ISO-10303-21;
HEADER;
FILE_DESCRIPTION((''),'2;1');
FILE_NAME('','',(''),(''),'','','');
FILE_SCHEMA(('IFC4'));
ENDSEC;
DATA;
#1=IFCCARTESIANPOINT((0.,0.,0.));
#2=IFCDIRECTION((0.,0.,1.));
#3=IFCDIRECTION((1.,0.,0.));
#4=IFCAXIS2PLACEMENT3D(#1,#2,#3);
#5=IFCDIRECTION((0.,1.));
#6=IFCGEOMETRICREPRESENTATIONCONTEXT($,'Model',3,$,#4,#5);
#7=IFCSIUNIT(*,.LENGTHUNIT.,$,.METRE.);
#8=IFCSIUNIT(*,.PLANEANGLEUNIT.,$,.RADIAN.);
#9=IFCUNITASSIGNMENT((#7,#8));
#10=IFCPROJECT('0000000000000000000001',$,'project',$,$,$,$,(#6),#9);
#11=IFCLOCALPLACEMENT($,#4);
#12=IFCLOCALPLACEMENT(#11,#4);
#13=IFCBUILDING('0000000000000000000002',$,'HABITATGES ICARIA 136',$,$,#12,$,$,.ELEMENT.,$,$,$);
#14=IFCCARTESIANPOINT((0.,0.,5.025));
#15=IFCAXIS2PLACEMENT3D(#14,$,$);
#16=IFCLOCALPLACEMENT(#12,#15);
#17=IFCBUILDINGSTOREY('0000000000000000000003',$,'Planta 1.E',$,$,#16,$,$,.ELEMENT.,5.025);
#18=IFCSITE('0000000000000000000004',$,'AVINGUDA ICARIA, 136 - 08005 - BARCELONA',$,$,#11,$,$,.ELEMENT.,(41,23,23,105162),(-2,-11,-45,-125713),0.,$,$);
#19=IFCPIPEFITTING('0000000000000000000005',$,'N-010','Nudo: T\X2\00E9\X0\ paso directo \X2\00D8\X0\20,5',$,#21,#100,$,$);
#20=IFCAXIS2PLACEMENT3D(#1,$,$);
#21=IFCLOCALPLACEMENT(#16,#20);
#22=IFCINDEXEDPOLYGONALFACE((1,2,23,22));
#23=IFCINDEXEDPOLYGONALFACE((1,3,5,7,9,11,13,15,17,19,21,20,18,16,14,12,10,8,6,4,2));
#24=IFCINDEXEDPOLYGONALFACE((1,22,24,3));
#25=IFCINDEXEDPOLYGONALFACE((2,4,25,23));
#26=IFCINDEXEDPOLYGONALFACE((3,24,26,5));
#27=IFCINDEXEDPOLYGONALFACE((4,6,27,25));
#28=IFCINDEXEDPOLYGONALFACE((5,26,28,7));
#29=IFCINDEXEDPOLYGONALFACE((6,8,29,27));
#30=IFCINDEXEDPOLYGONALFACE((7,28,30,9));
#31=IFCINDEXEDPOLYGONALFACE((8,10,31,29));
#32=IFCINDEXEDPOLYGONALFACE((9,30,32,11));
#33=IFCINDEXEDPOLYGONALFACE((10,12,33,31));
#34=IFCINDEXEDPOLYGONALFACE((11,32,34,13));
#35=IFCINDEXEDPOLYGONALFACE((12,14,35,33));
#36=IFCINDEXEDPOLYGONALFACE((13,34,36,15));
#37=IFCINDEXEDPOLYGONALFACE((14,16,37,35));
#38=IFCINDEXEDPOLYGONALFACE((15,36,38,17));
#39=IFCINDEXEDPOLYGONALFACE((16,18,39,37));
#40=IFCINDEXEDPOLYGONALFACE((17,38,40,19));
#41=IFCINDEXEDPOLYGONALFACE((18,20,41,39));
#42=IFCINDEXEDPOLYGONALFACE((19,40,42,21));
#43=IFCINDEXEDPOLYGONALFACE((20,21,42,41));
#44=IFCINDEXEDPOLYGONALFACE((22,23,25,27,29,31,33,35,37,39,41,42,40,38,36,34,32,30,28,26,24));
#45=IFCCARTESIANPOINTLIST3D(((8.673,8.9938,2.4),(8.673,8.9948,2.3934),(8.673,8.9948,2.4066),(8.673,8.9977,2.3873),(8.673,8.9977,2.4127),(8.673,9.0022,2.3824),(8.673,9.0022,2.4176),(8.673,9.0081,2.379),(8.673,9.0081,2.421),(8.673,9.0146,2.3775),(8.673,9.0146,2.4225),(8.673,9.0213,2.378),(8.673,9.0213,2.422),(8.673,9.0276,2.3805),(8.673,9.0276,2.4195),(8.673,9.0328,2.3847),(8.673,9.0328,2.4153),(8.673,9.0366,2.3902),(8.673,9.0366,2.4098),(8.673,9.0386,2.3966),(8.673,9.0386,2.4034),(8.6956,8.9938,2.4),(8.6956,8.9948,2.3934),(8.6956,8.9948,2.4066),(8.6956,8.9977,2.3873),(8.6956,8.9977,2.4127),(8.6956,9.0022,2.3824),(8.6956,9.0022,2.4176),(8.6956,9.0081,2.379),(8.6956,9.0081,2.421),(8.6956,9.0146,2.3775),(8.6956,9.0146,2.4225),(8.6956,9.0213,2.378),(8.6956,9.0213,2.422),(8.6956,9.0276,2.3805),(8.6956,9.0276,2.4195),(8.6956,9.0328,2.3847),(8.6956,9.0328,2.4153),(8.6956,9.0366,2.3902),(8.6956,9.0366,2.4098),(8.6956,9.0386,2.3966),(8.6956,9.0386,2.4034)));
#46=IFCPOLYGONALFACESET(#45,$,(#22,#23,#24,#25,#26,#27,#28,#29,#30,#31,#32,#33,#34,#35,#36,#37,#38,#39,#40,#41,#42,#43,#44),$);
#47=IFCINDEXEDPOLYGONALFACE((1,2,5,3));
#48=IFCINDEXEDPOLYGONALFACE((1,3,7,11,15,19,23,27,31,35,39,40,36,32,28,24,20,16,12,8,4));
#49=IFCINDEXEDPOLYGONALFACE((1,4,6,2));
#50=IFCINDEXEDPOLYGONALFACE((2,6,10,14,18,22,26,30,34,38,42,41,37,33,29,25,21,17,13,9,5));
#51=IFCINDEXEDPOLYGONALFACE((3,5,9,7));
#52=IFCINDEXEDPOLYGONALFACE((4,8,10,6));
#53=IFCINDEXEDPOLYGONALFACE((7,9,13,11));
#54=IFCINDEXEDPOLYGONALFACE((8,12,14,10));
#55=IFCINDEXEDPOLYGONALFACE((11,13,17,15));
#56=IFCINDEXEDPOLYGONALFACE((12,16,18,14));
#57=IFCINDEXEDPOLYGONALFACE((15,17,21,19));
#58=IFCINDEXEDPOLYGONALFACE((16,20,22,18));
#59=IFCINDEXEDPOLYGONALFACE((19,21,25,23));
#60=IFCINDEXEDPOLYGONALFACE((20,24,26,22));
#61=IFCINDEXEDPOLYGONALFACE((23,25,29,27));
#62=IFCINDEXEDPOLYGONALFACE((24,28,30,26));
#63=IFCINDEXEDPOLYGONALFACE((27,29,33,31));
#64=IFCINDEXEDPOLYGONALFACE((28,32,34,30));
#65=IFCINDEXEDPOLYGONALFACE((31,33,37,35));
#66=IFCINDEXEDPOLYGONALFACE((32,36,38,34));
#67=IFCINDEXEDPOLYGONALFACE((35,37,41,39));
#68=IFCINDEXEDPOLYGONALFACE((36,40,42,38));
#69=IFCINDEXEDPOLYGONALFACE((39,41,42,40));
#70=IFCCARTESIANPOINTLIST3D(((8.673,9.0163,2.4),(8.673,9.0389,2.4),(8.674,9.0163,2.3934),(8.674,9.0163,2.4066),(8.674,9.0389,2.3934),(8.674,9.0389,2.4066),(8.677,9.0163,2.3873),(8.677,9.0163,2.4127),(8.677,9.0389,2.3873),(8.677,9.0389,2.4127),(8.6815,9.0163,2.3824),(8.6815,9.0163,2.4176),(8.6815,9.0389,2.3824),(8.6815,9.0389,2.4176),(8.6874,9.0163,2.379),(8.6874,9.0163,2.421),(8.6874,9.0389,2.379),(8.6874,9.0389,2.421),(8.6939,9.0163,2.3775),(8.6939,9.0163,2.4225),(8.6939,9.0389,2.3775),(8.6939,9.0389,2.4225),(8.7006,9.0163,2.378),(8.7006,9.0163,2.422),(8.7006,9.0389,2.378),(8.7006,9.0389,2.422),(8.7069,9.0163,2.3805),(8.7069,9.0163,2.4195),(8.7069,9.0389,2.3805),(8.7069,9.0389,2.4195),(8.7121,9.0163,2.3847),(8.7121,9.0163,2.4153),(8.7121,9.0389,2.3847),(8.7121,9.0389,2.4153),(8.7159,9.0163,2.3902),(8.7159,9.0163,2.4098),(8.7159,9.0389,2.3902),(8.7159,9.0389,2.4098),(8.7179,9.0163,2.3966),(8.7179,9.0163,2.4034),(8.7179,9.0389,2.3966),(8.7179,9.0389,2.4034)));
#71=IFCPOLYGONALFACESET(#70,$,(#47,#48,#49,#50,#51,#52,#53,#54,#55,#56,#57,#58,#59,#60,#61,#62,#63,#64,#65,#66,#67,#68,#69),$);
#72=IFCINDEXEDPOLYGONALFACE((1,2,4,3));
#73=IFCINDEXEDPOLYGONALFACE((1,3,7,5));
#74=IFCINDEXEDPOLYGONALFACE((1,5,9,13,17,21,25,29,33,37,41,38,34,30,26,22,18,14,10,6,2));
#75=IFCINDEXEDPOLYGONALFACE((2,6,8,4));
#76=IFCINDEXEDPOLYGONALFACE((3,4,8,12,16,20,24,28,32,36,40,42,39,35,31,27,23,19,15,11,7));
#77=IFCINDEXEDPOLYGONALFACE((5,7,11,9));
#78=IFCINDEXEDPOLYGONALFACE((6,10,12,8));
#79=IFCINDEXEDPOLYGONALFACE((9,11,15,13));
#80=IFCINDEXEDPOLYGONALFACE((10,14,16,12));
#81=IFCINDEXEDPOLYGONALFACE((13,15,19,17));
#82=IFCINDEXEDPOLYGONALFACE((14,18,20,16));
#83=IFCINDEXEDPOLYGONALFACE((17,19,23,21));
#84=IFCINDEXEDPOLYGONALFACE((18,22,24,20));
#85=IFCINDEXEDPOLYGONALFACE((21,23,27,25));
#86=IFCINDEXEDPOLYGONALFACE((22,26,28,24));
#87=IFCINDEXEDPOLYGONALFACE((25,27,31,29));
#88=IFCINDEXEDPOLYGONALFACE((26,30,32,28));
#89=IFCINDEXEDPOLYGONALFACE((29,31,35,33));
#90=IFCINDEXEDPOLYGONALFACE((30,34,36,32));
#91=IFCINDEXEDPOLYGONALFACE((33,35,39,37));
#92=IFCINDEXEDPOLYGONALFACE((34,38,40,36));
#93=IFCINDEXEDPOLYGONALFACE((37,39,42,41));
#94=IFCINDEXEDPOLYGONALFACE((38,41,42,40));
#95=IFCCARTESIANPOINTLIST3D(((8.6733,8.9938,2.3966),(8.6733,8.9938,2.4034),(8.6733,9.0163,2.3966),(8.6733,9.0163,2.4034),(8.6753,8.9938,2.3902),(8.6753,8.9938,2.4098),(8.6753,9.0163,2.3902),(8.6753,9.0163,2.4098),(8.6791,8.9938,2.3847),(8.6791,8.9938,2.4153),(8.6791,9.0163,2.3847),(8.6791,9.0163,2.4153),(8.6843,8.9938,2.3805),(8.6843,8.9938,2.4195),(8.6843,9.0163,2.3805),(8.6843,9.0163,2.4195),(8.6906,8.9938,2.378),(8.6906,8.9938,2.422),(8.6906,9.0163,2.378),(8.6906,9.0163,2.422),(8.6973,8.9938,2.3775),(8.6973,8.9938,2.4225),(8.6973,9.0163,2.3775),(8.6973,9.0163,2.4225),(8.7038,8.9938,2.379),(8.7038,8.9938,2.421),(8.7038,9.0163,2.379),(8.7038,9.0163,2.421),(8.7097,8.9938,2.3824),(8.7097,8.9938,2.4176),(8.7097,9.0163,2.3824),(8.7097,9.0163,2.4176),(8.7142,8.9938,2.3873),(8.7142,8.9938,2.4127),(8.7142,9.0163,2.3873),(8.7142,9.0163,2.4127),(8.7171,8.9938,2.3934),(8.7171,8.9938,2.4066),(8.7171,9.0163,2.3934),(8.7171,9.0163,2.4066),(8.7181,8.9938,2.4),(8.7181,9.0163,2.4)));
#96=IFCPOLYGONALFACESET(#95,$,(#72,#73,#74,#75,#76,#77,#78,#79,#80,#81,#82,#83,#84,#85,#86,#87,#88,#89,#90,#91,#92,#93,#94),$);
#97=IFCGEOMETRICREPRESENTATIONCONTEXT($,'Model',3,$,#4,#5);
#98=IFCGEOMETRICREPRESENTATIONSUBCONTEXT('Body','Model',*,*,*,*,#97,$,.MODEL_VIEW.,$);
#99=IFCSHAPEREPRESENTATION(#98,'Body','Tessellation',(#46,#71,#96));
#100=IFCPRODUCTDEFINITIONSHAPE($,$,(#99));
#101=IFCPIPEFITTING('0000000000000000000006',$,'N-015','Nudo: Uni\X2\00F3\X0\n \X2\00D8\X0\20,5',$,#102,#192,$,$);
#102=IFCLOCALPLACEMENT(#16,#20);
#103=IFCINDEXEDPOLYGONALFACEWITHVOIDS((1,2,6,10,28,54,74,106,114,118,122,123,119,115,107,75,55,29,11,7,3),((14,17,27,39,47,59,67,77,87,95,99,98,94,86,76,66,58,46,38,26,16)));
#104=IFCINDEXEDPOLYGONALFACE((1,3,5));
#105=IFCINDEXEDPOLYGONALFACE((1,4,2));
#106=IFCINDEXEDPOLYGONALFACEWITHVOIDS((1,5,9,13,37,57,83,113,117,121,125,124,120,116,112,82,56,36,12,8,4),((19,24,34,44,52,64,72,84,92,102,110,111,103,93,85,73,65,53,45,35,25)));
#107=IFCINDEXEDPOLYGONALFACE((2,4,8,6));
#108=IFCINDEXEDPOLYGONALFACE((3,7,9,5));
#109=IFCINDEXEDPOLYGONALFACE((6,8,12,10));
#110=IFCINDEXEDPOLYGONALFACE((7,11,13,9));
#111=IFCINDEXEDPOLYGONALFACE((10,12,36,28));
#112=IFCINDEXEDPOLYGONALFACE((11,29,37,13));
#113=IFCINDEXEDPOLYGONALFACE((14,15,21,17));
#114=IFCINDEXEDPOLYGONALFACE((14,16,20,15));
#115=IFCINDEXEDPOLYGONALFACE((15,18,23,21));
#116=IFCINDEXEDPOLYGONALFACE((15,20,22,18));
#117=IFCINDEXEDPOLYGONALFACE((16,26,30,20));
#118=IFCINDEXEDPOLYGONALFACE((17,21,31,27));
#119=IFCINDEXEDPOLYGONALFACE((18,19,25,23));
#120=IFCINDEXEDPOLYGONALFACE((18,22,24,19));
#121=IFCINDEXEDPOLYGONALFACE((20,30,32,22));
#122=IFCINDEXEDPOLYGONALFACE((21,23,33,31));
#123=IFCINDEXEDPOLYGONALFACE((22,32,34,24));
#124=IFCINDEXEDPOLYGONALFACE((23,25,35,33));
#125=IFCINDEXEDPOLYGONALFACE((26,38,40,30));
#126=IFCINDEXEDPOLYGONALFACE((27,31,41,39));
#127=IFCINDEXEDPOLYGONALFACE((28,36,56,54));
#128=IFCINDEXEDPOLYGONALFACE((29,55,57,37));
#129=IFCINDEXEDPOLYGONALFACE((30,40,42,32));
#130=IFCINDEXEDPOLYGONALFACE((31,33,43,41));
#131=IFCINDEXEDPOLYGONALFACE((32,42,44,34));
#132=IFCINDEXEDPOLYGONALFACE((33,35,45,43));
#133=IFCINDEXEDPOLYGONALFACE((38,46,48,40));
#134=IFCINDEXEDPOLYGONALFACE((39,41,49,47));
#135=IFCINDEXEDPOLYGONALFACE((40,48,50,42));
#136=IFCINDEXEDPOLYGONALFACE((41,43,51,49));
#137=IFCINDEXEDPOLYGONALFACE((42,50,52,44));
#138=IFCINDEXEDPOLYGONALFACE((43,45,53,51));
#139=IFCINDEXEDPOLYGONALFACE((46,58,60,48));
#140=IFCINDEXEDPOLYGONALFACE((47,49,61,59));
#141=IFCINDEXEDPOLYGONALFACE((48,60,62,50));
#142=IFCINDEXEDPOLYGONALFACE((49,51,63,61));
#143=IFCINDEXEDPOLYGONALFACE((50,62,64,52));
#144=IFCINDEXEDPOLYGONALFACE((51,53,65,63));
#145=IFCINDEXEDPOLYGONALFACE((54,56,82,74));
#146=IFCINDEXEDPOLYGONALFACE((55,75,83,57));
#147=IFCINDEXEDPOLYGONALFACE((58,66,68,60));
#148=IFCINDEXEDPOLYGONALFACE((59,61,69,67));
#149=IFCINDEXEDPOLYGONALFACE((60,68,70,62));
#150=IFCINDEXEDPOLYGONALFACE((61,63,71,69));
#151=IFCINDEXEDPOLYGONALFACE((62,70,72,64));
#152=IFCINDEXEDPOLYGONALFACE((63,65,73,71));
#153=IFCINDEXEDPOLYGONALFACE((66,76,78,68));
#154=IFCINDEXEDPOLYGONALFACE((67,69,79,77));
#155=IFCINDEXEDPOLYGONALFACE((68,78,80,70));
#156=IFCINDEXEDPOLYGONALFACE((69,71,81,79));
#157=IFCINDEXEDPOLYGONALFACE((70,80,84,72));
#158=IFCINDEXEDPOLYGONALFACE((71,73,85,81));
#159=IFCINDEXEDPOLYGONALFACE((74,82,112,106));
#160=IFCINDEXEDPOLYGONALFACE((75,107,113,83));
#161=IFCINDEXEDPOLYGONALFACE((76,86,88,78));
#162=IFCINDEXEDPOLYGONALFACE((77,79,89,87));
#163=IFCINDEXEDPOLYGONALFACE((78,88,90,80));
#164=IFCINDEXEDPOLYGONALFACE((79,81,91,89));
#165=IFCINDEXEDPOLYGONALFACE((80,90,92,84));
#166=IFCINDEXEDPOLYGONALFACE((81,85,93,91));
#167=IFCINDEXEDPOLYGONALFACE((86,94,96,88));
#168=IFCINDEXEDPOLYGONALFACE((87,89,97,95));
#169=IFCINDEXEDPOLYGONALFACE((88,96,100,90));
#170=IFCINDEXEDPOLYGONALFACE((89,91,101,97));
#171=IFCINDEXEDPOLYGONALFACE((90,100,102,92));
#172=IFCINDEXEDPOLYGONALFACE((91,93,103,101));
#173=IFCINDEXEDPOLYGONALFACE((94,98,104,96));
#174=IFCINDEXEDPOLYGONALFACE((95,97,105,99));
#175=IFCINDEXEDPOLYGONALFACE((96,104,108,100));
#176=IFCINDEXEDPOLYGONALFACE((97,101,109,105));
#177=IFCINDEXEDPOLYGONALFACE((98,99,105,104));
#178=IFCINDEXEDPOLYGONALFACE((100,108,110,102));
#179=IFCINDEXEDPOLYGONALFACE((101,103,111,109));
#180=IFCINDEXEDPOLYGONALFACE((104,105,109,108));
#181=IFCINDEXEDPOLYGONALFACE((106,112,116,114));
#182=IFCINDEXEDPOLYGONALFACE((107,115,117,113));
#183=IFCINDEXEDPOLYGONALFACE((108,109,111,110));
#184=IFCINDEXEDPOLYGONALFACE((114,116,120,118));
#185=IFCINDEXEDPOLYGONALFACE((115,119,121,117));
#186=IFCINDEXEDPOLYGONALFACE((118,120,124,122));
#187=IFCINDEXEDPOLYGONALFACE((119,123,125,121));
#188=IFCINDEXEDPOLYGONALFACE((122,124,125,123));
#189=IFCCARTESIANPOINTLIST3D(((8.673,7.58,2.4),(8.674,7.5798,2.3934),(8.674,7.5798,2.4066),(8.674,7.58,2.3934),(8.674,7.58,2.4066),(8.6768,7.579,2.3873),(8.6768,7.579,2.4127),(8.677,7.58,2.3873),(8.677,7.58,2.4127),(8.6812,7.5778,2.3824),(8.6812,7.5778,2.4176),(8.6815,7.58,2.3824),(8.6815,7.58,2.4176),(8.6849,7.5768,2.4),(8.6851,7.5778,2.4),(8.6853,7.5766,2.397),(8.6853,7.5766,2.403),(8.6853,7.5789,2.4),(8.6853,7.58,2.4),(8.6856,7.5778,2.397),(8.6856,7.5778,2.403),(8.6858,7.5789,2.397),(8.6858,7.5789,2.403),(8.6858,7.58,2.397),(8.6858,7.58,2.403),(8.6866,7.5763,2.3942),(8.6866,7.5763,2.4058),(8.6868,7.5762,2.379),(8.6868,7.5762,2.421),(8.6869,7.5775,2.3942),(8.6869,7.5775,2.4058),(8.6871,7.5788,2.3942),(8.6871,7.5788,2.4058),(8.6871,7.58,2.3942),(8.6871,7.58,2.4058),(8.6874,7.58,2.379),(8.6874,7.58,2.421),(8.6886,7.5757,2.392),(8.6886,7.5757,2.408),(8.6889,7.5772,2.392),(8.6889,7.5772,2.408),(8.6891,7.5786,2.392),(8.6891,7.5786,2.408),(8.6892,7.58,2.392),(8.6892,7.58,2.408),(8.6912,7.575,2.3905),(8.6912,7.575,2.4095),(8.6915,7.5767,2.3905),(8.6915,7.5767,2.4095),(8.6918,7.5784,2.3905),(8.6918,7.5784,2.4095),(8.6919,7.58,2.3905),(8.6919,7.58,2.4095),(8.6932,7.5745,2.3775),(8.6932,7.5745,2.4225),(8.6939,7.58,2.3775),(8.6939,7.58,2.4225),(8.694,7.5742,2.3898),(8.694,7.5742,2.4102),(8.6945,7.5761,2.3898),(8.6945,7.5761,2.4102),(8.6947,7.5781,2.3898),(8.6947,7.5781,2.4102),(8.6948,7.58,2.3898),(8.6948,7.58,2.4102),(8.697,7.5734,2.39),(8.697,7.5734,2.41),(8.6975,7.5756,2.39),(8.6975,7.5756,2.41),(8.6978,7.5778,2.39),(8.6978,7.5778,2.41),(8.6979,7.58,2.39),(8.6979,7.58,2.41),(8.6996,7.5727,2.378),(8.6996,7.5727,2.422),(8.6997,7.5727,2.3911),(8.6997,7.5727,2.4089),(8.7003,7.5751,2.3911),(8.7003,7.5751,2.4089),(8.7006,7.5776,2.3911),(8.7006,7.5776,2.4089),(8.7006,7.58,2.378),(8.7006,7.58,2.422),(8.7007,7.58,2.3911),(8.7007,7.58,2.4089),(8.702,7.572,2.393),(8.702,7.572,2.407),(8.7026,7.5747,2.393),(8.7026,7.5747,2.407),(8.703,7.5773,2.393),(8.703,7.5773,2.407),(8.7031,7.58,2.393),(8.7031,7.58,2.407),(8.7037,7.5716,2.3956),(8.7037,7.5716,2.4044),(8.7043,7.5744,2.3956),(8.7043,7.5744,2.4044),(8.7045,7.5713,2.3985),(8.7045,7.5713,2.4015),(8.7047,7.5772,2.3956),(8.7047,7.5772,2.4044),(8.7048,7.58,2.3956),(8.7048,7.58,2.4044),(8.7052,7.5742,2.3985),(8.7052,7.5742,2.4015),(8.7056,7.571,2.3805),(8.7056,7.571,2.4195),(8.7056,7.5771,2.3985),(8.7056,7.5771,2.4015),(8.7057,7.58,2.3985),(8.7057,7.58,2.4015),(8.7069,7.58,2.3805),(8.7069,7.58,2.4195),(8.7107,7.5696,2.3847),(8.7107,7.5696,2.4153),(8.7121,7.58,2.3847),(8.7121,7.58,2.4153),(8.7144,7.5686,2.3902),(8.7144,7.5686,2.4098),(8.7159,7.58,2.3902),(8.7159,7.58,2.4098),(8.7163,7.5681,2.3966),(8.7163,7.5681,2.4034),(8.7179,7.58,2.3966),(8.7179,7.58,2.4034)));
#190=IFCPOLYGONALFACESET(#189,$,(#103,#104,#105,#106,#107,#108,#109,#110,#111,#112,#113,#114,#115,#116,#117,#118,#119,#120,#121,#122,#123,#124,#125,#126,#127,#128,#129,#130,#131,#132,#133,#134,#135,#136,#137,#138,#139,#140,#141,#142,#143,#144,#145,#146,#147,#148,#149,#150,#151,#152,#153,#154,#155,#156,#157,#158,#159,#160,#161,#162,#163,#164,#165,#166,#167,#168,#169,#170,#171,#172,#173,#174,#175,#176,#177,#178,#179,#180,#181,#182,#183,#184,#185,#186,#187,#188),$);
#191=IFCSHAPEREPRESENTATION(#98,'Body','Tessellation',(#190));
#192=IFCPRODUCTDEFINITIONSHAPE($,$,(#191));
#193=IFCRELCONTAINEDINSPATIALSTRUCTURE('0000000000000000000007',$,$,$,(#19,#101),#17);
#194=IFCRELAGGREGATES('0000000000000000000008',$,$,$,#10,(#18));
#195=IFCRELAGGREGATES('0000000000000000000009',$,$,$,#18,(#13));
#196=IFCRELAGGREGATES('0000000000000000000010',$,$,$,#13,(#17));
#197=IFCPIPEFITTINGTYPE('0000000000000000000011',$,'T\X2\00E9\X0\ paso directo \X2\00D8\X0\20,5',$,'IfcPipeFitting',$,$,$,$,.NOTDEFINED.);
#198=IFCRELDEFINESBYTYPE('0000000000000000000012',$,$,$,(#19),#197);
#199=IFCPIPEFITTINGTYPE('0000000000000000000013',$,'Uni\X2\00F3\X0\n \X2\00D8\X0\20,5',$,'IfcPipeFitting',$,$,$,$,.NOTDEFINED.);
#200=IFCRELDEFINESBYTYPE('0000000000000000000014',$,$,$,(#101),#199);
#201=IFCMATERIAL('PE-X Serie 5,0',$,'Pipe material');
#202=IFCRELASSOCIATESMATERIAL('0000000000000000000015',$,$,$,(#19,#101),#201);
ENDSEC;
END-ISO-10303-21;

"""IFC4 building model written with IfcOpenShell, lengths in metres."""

from ifc_helpers import new_model, entity, si_unit, direction, frame, origin_with_axes, origin_2d_with_axis, place, context, subcontext, project, spatial, circle, extrude, source, transform, mapped, material, type_object, element, save


model = new_model("IFC4")

# Units and contexts
model_context_1 = context("Model", 3, world=origin_with_axes(), true_north=direction((0.0, 1.0)))
model_context_2 = context("Model", 3, world=origin_with_axes(), true_north=direction((0.0, 1.0)))
body_context_1 = subcontext(model_context_2, "Body", "Model", "MODEL_VIEW")
ifc_project = project(units=[si_unit("LENGTHUNIT", "METRE"), si_unit("PLANEANGLEUNIT", "RADIAN")], contexts=[model_context_1])

# Site, building, storey
site_placement = place(None, origin_with_axes())
site = spatial("IfcSite", under=ifc_project, at=site_placement, Name="AVINGUDA ICARIA, 136 - 08005 - BARCELONA", CompositionType="ELEMENT", RefLatitude=(41, 23, 23, 105162), RefLongitude=(-2, -11, -45, -125713), RefElevation=0.0)
building_placement = place(site_placement, origin_with_axes())
building = spatial("IfcBuilding", under=site, at=building_placement, Name="HABITATGES ICARIA 136", CompositionType="ELEMENT")
storey_placement = place(building_placement, frame((0.0, 0.0, 5.025)))
storey = spatial("IfcBuildingStorey", under=building, at=storey_placement, Name="Planta 1.E", CompositionType="ELEMENT", Elevation=5.025)

# Shared definitions
ifc_material_1 = material(Name="PE-X Serie 5,0", Category="Pipe material")
placement_1 = place(None, origin_with_axes())
placement_2 = place(placement_1, origin_with_axes())
placement_3 = place(placement_2, frame((0.0, 0.0, 5.025)))

# Shared definitions
pipe_fitting_type_1 = type_object("IfcPipeFittingType", Name="Unión Ø20,5", ApplicableOccurrence="IfcPipeFitting", PredefinedType="NOTDEFINED")

# Pipe fittings
pipe_fitting_type_2 = type_object("IfcPipeFittingType", Name="Té paso directo Ø20,5", ApplicableOccurrence="IfcPipeFitting", PredefinedType="NOTDEFINED")
shared_shape_1 = source(origin_with_axes(), body_context_1, "Body", "SweptSolid", [
    extrude(circle(Radius=0.0226, at=origin_2d_with_axis()), frame((0.0, 0.0, 0.0), z_axis=(-1.0, 0.0, 0.0), x_axis=(0.0, -1.0, 0.0)), (0.0, 0.0, 1.0), 0.0226),
    extrude(circle(Radius=0.0226, at=origin_2d_with_axis()), frame((0.0, 0.0, 0.0), z_axis=(0.0, 1.0, 0.0), x_axis=(-1.0, 0.0, 0.0)), (0.0, 0.0, 1.0), 0.0226),
    extrude(circle(Radius=0.0226, at=origin_2d_with_axis()), frame((0.0, 0.0, 0.0), z_axis=(0.0, -1.0, 0.0), x_axis=(1.0, 0.0, 0.0)), (0.0, 0.0, 1.0), 0.0226),
])
pipe_fitting_1_placement = place(placement_3, origin_with_axes())
element("IfcPipeFitting", 1, at=pipe_fitting_1_placement, inside=storey, type_object=pipe_fitting_type_2, material=ifc_material_1, Name="N-010", Description="Nudo: Té paso directo Ø20,5", context=body_context_1, shape_type="MappedRepresentation", body=[
    mapped(shared_shape_1, transform((8.6956, 9.0163, 2.4), x_axis=(1.0, 0.0, 0.0), y_axis=(0.0, 1.0, 0.0), z_axis=(0.0, 0.0, 1.0), scale=1.0)),
])
shared_shape_2 = source(origin_with_axes(), body_context_1, "Body", "SweptSolid", [
    entity("IfcRevolvedAreaSolid", entity("IfcCircleHollowProfileDef", "AREA", None, entity("IfcAxis2Placement2D", entity("IfcCartesianPoint", [0.0, 0.0]), entity("IfcDirection", [1.0, 0.0])), 0.0226, 0.0123), entity("IfcAxis2Placement3D", entity("IfcCartesianPoint", [0.0008, 0.003, 0.0]), entity("IfcDirection", [-0.266843, -0.96374, 0.0]), entity("IfcDirection", [0.96374, -0.266843, 0.0])), entity("IfcAxis1Placement", entity("IfcCartesianPoint", [0.0226, 0.0, 0.0]), entity("IfcDirection", [0.0, 1.0, 0.0])), 0.270116),
])
pipe_fitting_2_placement = place(placement_3, origin_with_axes())
element("IfcPipeFitting", 2, at=pipe_fitting_2_placement, inside=storey, type_object=pipe_fitting_type_1, material=ifc_material_1, Name="N-015", Description="Nudo: Unión Ø20,5", context=body_context_1, shape_type="MappedRepresentation", body=[
    mapped(shared_shape_2, transform((8.6956, 7.577, 2.4), x_axis=(-1.0, 0.0, 0.0), y_axis=(0.0, -1.0, 0.0), z_axis=(0.0, 0.0, 1.0), scale=1.0)),
])

save(model, "model.ifc")
